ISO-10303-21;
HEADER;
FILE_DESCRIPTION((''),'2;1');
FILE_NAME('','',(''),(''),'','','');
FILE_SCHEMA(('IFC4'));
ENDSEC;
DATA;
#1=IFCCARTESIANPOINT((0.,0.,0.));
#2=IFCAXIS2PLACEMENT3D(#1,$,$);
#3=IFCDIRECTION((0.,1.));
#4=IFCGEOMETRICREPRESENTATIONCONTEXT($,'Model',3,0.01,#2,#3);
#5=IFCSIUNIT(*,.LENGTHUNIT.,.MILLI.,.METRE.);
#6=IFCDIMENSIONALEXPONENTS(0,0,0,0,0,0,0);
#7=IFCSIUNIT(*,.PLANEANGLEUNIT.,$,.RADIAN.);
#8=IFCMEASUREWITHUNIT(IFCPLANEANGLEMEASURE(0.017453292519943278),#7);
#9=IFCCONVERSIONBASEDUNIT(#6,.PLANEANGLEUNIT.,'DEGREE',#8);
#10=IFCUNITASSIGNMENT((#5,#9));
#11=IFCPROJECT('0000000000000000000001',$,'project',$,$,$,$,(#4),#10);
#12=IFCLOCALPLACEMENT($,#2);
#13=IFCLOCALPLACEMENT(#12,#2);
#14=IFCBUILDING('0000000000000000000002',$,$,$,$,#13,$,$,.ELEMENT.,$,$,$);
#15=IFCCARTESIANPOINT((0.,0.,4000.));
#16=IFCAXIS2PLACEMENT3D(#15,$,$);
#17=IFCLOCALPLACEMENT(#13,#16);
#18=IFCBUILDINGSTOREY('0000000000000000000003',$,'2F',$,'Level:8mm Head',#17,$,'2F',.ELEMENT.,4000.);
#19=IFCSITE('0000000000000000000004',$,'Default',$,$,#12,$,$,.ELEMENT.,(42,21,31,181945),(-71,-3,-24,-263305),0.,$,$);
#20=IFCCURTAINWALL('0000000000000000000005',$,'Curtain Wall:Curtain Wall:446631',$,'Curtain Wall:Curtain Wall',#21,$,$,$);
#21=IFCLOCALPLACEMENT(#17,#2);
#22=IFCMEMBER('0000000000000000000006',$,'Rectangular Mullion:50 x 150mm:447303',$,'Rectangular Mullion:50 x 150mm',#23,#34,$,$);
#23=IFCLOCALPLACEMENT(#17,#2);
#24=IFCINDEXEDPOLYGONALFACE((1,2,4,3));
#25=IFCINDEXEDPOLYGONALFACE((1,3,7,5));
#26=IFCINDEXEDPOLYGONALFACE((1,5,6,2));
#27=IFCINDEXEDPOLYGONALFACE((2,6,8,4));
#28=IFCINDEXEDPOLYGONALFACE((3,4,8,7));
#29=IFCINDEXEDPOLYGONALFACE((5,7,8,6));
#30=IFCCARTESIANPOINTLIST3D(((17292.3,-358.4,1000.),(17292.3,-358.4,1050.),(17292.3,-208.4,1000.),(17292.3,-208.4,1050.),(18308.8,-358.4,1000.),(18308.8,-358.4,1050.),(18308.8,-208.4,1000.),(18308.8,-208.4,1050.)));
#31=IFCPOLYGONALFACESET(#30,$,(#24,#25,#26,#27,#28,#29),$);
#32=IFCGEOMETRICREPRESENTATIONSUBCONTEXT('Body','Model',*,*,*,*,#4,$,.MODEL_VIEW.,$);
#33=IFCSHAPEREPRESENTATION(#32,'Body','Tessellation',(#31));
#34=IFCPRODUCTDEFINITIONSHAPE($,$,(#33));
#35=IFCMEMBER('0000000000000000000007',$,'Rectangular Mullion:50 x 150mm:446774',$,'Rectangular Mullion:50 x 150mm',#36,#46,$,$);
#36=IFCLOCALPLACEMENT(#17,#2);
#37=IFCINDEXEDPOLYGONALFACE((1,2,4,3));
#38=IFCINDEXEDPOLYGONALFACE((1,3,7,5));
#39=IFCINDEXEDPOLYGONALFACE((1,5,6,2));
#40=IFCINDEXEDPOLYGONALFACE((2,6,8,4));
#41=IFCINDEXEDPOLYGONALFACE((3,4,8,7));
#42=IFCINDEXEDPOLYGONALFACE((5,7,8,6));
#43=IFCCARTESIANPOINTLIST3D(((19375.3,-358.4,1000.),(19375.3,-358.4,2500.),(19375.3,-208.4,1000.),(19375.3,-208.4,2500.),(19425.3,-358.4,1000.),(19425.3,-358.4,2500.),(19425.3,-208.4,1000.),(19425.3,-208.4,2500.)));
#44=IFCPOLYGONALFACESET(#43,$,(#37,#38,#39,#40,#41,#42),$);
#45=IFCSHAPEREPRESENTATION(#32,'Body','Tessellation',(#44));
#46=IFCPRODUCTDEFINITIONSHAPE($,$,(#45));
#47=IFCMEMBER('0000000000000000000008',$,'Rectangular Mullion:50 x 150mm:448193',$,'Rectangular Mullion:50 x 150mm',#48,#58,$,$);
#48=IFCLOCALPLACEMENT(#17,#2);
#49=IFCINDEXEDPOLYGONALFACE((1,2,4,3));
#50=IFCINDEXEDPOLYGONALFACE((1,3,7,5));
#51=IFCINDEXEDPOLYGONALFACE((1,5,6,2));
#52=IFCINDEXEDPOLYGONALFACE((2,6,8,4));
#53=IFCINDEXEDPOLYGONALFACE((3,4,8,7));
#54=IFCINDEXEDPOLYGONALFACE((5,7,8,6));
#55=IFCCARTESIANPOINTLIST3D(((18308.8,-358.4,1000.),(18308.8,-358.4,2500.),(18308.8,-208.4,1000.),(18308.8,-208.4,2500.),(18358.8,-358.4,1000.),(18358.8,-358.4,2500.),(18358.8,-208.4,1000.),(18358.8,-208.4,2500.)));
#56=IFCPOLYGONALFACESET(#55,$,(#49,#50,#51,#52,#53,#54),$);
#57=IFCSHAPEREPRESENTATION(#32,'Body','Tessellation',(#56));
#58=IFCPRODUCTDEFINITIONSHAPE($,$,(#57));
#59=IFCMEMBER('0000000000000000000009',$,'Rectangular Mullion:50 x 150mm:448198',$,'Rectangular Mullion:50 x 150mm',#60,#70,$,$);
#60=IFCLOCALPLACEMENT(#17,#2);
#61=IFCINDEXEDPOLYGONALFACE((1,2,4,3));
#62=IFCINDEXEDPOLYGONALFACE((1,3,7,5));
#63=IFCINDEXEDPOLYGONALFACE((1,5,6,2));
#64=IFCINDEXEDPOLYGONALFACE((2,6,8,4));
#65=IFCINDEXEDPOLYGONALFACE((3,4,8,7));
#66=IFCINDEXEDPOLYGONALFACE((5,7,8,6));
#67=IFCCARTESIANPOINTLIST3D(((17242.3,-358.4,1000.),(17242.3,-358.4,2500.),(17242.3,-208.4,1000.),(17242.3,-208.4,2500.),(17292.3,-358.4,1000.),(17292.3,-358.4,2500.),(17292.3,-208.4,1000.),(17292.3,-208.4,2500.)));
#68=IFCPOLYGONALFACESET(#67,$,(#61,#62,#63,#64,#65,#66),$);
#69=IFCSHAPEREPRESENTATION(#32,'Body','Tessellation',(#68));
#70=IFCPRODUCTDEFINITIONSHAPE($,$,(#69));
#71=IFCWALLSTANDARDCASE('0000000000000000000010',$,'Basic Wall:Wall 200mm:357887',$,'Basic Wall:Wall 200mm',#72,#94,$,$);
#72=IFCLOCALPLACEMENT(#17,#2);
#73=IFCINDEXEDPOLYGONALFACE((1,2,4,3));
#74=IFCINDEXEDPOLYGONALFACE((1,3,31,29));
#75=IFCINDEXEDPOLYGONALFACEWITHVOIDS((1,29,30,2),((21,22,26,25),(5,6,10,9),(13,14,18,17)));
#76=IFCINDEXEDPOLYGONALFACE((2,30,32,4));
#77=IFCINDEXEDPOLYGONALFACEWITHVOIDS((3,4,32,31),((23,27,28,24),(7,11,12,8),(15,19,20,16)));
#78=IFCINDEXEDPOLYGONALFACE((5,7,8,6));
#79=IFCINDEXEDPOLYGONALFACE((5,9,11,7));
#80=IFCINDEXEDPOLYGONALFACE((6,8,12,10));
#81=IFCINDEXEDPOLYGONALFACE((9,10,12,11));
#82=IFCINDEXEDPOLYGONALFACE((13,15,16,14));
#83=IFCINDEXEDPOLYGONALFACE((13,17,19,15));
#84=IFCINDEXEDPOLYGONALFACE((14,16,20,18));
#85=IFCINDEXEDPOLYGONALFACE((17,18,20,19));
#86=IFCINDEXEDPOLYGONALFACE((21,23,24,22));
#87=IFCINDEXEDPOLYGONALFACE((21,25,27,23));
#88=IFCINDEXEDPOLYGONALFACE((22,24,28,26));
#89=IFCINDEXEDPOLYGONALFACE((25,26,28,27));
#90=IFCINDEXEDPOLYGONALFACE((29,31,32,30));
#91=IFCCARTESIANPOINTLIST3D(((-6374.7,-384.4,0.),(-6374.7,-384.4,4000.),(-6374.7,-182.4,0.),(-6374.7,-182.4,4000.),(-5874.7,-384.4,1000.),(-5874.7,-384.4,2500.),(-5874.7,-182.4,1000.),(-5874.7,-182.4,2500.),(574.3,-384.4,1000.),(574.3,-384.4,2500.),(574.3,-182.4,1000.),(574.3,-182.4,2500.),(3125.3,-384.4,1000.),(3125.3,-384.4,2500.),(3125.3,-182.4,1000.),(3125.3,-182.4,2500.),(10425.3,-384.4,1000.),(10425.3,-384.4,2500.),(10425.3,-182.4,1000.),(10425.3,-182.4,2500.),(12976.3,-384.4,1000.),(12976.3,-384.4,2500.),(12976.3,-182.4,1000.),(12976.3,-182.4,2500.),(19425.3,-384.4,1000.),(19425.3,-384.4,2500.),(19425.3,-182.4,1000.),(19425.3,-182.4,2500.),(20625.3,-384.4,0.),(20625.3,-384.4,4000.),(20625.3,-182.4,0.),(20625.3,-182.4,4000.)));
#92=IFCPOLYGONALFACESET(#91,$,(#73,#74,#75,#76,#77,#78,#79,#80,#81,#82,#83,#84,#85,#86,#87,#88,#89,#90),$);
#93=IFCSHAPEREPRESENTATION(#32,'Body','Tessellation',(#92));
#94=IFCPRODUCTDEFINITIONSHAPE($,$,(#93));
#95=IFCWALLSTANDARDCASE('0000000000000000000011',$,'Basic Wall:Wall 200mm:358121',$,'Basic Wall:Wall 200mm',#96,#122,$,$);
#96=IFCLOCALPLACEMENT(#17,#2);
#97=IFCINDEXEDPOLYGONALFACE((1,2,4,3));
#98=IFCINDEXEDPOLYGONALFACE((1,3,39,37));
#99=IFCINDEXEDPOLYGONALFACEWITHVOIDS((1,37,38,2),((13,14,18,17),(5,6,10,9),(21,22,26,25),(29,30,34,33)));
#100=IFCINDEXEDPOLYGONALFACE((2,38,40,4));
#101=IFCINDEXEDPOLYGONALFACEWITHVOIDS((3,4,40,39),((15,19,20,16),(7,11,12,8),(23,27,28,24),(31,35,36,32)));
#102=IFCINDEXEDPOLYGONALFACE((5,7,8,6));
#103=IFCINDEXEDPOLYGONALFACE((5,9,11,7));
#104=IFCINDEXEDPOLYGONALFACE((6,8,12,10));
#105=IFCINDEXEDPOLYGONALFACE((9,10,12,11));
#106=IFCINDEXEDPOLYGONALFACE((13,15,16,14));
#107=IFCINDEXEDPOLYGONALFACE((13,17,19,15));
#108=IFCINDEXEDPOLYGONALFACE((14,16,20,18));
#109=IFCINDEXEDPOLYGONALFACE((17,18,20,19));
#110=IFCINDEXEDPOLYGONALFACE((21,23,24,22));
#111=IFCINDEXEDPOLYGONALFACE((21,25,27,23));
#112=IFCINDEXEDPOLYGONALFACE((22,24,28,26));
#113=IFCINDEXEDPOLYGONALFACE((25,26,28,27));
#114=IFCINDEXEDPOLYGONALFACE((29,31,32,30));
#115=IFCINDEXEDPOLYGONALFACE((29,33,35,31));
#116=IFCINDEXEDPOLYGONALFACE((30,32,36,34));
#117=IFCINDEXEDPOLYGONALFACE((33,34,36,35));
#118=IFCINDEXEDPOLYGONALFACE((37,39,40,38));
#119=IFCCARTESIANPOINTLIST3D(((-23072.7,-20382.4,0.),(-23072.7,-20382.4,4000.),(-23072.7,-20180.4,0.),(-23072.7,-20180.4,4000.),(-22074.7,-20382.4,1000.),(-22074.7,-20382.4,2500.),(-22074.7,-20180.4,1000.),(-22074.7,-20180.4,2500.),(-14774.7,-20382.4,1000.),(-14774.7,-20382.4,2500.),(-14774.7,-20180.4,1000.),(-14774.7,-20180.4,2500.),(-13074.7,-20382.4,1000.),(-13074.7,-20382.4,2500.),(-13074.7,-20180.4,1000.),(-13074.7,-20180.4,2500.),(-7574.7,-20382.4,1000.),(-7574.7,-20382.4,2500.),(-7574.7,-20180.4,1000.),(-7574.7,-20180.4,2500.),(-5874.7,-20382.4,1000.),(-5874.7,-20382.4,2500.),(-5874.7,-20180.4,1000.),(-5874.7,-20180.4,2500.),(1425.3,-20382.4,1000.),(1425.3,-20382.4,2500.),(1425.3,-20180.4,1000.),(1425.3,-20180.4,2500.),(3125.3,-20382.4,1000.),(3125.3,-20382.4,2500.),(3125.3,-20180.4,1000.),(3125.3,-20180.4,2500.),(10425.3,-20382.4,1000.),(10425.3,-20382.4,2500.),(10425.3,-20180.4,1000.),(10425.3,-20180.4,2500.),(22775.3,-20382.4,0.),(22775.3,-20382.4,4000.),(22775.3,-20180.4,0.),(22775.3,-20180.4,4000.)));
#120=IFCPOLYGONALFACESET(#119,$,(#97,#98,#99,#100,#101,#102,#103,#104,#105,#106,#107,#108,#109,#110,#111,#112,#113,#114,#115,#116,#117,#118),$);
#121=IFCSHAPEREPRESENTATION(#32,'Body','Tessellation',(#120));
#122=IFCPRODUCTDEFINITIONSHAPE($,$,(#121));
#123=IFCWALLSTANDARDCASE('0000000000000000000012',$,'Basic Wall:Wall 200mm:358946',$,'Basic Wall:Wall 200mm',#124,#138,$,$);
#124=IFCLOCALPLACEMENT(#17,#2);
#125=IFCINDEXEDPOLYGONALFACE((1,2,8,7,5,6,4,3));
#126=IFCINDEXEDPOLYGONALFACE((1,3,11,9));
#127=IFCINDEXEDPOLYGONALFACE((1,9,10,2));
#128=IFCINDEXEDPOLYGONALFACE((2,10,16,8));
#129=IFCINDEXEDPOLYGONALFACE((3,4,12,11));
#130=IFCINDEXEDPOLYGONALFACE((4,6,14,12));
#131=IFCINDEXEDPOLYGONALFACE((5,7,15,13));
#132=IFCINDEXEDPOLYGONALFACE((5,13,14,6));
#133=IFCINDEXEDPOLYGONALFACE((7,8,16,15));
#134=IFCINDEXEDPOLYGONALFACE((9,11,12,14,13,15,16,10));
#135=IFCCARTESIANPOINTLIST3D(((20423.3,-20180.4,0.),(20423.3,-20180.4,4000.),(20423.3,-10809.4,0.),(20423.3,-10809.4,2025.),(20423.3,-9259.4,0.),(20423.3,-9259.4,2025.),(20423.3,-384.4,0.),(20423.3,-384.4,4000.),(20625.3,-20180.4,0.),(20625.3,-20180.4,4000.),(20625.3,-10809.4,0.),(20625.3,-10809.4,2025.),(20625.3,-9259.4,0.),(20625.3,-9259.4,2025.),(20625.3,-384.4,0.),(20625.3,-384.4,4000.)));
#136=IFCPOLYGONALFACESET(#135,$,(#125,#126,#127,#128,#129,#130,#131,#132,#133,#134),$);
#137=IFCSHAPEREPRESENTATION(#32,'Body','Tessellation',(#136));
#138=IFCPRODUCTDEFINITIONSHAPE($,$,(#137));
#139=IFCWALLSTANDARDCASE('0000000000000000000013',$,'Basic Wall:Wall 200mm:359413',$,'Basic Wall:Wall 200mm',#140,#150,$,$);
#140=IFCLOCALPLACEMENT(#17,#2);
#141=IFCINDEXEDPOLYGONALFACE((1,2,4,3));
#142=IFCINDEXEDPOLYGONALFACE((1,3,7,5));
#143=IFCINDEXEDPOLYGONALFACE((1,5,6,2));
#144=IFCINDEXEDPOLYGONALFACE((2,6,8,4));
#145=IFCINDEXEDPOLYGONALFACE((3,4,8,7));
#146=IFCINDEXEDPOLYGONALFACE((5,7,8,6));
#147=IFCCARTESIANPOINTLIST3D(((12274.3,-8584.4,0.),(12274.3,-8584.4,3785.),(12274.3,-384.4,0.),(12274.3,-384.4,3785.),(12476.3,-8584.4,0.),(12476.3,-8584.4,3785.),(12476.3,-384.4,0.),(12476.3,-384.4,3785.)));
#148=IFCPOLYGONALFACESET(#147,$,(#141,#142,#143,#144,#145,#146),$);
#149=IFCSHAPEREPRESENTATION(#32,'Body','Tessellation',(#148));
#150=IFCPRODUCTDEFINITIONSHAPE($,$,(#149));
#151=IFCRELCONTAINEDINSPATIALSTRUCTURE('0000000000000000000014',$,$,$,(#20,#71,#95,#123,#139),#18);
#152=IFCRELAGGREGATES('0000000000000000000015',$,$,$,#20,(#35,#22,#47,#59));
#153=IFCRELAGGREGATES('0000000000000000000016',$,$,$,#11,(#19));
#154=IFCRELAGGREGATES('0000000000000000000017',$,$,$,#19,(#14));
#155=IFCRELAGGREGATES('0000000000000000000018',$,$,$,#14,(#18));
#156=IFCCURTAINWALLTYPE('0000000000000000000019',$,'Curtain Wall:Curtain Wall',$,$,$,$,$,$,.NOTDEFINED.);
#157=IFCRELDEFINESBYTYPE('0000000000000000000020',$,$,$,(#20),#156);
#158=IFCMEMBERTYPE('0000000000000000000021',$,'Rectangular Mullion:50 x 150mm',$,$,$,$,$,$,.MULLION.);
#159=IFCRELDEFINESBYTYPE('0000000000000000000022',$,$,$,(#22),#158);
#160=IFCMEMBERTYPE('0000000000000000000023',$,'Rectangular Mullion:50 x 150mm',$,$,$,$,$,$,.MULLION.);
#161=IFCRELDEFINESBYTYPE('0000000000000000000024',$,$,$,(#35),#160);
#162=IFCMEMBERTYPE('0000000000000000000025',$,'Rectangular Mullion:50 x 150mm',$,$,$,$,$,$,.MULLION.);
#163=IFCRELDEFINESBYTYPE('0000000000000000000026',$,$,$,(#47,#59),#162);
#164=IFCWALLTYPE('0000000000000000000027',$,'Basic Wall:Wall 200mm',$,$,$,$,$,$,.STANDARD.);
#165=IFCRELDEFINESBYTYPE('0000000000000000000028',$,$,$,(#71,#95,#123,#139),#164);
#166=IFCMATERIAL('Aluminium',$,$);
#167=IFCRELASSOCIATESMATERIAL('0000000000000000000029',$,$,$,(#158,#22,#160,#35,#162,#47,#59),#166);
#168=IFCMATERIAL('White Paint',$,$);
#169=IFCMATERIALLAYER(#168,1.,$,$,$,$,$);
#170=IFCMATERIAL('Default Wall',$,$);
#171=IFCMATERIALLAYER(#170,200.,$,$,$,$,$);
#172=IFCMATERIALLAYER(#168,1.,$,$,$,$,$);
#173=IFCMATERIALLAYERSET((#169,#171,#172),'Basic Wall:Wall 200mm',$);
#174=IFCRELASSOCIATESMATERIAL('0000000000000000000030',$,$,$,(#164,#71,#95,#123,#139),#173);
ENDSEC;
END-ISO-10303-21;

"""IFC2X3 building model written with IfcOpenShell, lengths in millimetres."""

from ifc_helpers import new_model, entity, si_unit, converted_unit, direction, frame, frame_2d, origin, origin_2d_with_axis, place, context, subcontext, project, spatial, polyline, rectangle, extrude, clip, bounded_halfspace, source, transform, mapped, material, layer, layer_set, layer_usage, type_object, type_shapes, element, aggregate, save


model = new_model("IFC2X3")

# Units and contexts
model_context = context("Model", 3, precision=0.01, world=origin(), true_north=direction((0.0, 1.0)))
body_context = subcontext(model_context, "Body", "Model", "MODEL_VIEW")
ifc_project = project(units=[si_unit("LENGTHUNIT", "METRE", prefix="MILLI"), converted_unit("PLANEANGLEUNIT", "DEGREE", entity("IfcPlaneAngleMeasure", 0.017453292519943278), si_unit("PLANEANGLEUNIT", "RADIAN"), dimensions=[0, 0, 0, 0, 0, 0, 0])], contexts=[model_context])

# Site, building, storey
site_placement = place(None, origin())
site = spatial("IfcSite", under=ifc_project, at=site_placement, Name="Default", CompositionType="ELEMENT", RefLatitude=(42, 21, 31, 181945), RefLongitude=(-71, -3, -24, -263305), RefElevation=0.0)
building_placement = place(site_placement, origin())
building = spatial("IfcBuilding", under=site, at=building_placement, CompositionType="ELEMENT")
storey_placement = place(building_placement, frame((0.0, 0.0, 4000.0)))
storey = spatial("IfcBuildingStorey", under=building, at=storey_placement, Name="2F", ObjectType="Level:8mm Head", LongName="2F", CompositionType="ELEMENT", Elevation=4000.0)

# Curtain wall, members
curtain_wall_type = type_object("IfcCurtainWallType", Name="Curtain Wall:Curtain Wall", PredefinedType="NOTDEFINED")
ifc_material_1 = material(Name="Aluminium")
curtain_wall_1_placement = place(storey_placement, frame((0.0, 0.0, -4000.0)))
curtain_wall_1 = element("IfcCurtainWall", 1, at=curtain_wall_1_placement, inside=storey, type_object=curtain_wall_type, Name="Curtain Wall:Curtain Wall:446631", ObjectType="Curtain Wall:Curtain Wall")
member_type_1 = type_object("IfcMemberType", Name="Rectangular Mullion:50 x 150mm", PredefinedType="MULLION", material=ifc_material_1)
shared_shape_1 = source(origin(), body_context, "Body", "SweptSolid", [
    extrude(rectangle(XDim=50.0, YDim=150.0, at=origin_2d_with_axis()), frame((-25.0, 0.0, -1016.5), z_axis=(0.0, 0.0, 1.0), x_axis=(-1.0, 0.0, 0.0)), (0.0, 0.0, 1.0), 1016.5),
])
type_shapes(member_type_1, [shared_shape_1])
member_1_placement = place(curtain_wall_1_placement, frame((18308.8, -283.4, 5000.0), z_axis=(1.0, 0.0, 0.0), x_axis=(0.0, 0.0, -1.0)))
member_1 = element("IfcMember", 2, at=member_1_placement, type_object=member_type_1, material=ifc_material_1, Name="Rectangular Mullion:50 x 150mm:447303", ObjectType="Rectangular Mullion:50 x 150mm", context=body_context, shape_type="MappedRepresentation", body=[
    mapped(shared_shape_1, transform((0.0, 0.0, 0.0), scale=1.0)),
])
member_type_2 = type_object("IfcMemberType", Name="Rectangular Mullion:50 x 150mm", PredefinedType="MULLION", material=ifc_material_1)
shared_shape_2 = source(origin(), body_context, "Body", "SweptSolid", [
    extrude(rectangle(XDim=50.0, YDim=150.0, at=origin_2d_with_axis()), frame((-25.0, 0.0, -1500.0), z_axis=(0.0, 0.0, 1.0), x_axis=(-1.0, 0.0, 0.0)), (0.0, 0.0, 1.0), 1500.0),
])
type_shapes(member_type_2, [shared_shape_2])
member_2_placement = place(curtain_wall_1_placement, frame((19425.3, -283.4, 6500.0)))
member_2 = element("IfcMember", 3, at=member_2_placement, type_object=member_type_2, material=ifc_material_1, Name="Rectangular Mullion:50 x 150mm:446774", ObjectType="Rectangular Mullion:50 x 150mm", context=body_context, shape_type="MappedRepresentation", body=[
    mapped(shared_shape_2, transform((0.0, 0.0, 0.0), scale=1.0)),
])
member_type_3 = type_object("IfcMemberType", Name="Rectangular Mullion:50 x 150mm", PredefinedType="MULLION", material=ifc_material_1)
shared_shape_3 = source(origin(), body_context, "Body", "SweptSolid", [
    extrude(rectangle(XDim=50.0, YDim=150.0, at=origin_2d_with_axis()), frame((0.0, 0.0, -1500.0), z_axis=(0.0, 0.0, 1.0), x_axis=(-1.0, 0.0, 0.0)), (0.0, 0.0, 1.0), 1500.0),
])
type_shapes(member_type_3, [shared_shape_3])
member_3_placement = place(curtain_wall_1_placement, frame((18333.8, -283.4, 5000.0), z_axis=(0.0, 0.0, -1.0), x_axis=(-1.0, 0.0, 0.0)))
member_3 = element("IfcMember", 4, at=member_3_placement, type_object=member_type_3, material=ifc_material_1, Name="Rectangular Mullion:50 x 150mm:448193", ObjectType="Rectangular Mullion:50 x 150mm", context=body_context, shape_type="MappedRepresentation", body=[
    mapped(shared_shape_3, transform((0.0, 0.0, 0.0), scale=1.0)),
])
member_4_placement = place(curtain_wall_1_placement, frame((17267.3, -283.4, 5000.0), z_axis=(0.0, 0.0, -1.0), x_axis=(-1.0, 0.0, 0.0)))
member_4 = element("IfcMember", 5, at=member_4_placement, type_object=member_type_3, material=ifc_material_1, Name="Rectangular Mullion:50 x 150mm:448198", ObjectType="Rectangular Mullion:50 x 150mm", context=body_context, shape_type="MappedRepresentation", body=[
    mapped(shared_shape_3, transform((0.0, 0.0, 0.0), scale=1.0)),
])

aggregate(curtain_wall_1, [member_2, member_1, member_3, member_4])

# Walls, openings
ifc_material_2 = material(Name="White Paint")
ifc_layer_1 = layer(ifc_material_2, 1.0)
ifc_material_3 = material(Name="Default Wall")
ifc_layer_2 = layer(ifc_material_3, 200.0)
ifc_layer_3 = layer(ifc_material_2, 1.0)
ifc_layer_set_1 = layer_set([ifc_layer_1, ifc_layer_2, ifc_layer_3], Name="Basic Wall:Wall 200mm")
ifc_layer_usage_1 = layer_usage(ifc_layer_set_1, "AXIS2", "POSITIVE", -101.0)
wall_type_1 = type_object("IfcWallType", Name="Basic Wall:Wall 200mm", PredefinedType="STANDARD", material=ifc_layer_set_1)
wall_1_placement = place(storey_placement, frame((20625.3, -283.4, 0.0), z_axis=(0.0, 0.0, 1.0), x_axis=(-1.0, 0.0, 0.0)))
wall_1 = element("IfcWallStandardCase", 6, at=wall_1_placement, inside=storey, type_object=wall_type_1, material=ifc_layer_usage_1, Name="Basic Wall:Wall 200mm:357887", ObjectType="Basic Wall:Wall 200mm", context=body_context, shape_type="SweptSolid", body=[
    extrude(rectangle(XDim=27000.0, YDim=202.0, at=frame_2d((13500.0, 0.0), x_axis=(-1.0, 0.0))), origin(), (0.0, 0.0, 1.0), 4000.0),
])
opening_1_placement = place(wall_1_placement, origin())
element("IfcOpeningElement", 7, at=opening_1_placement, cuts=wall_1, ObjectType="Opening", context=body_context, shape_type="SweptSolid", body=[
    extrude(rectangle(XDim=1500.0, YDim=6449.0, at=frame_2d((0.0, 0.0), x_axis=(0.0, 1.0))), frame((4424.5, 101.0, 1750.0), z_axis=(0.0, -1.0, 0.0), x_axis=(-1.0, 0.0, 0.0)), (0.0, 0.0, 1.0), 202.0),
])
opening_2_placement = place(wall_1_placement, origin())
element("IfcOpeningElement", 8, at=opening_2_placement, cuts=wall_1, ObjectType="Opening", context=body_context, shape_type="SweptSolid", body=[
    extrude(rectangle(XDim=1500.0, YDim=7300.0, at=frame_2d((0.0, 0.0), x_axis=(0.0, 1.0))), frame((13850.0, 101.0, 1750.0), z_axis=(0.0, -1.0, 0.0), x_axis=(-1.0, 0.0, 0.0)), (0.0, 0.0, 1.0), 202.0),
])
opening_3_placement = place(wall_1_placement, origin())
element("IfcOpeningElement", 9, at=opening_3_placement, cuts=wall_1, ObjectType="Opening", context=body_context, shape_type="SweptSolid", body=[
    extrude(rectangle(XDim=1500.0, YDim=6449.0, at=frame_2d((0.0, 0.0), x_axis=(0.0, -1.0))), frame((23275.5, 101.0, 1750.0), z_axis=(0.0, 1.0, 0.0), x_axis=(-1.0, 0.0, 0.0)), (0.0, 0.0, -1.0), 202.0),
])
ifc_layer_usage_2 = layer_usage(ifc_layer_set_1, "AXIS2", "NEGATIVE", 101.0)
wall_2_placement = place(storey_placement, frame((22775.3, -20281.4, 0.0), z_axis=(0.0, 0.0, 1.0), x_axis=(-1.0, 0.0, 0.0)))
wall_2 = element("IfcWallStandardCase", 10, at=wall_2_placement, inside=storey, type_object=wall_type_1, material=ifc_layer_usage_2, Name="Basic Wall:Wall 200mm:358121", ObjectType="Basic Wall:Wall 200mm", context=body_context, shape_type="SweptSolid", body=[
    extrude(rectangle(XDim=45848.0, YDim=202.0, at=frame_2d((22924.0, 0.0), x_axis=(-1.0, 0.0))), origin(), (0.0, 0.0, 1.0), 4000.0),
])
opening_4_placement = place(wall_2_placement, origin())
element("IfcOpeningElement", 11, at=opening_4_placement, cuts=wall_2, ObjectType="Opening", context=body_context, shape_type="SweptSolid", body=[
    extrude(rectangle(XDim=1500.0, YDim=7300.0, at=frame_2d((0.0, 0.0), x_axis=(1.0, 0.0))), frame((41200.0, 101.0, 1750.0), z_axis=(0.0, -1.0, 0.0), x_axis=(0.0, 0.0, -1.0)), (0.0, 0.0, 1.0), 202.0),
])
opening_5_placement = place(wall_2_placement, origin())
element("IfcOpeningElement", 12, at=opening_5_placement, cuts=wall_2, ObjectType="Opening", context=body_context, shape_type="SweptSolid", body=[
    extrude(rectangle(XDim=1500.0, YDim=5500.0, at=frame_2d((0.0, 0.0), x_axis=(1.0, 0.0))), frame((33100.0, 101.0, 1750.0), z_axis=(0.0, 1.0, 0.0), x_axis=(0.0, 0.0, -1.0)), (0.0, 0.0, -1.0), 202.0),
])
opening_6_placement = place(wall_2_placement, origin())
element("IfcOpeningElement", 13, at=opening_6_placement, cuts=wall_2, ObjectType="Opening", context=body_context, shape_type="SweptSolid", body=[
    extrude(rectangle(XDim=1500.0, YDim=7300.0, at=frame_2d((0.0, 0.0), x_axis=(1.0, 0.0))), frame((25000.0, 101.0, 1750.0), z_axis=(0.0, -1.0, 0.0), x_axis=(0.0, 0.0, -1.0)), (0.0, 0.0, 1.0), 202.0),
])
opening_7_placement = place(wall_2_placement, origin())
element("IfcOpeningElement", 14, at=opening_7_placement, cuts=wall_2, ObjectType="Opening", context=body_context, shape_type="SweptSolid", body=[
    extrude(rectangle(XDim=1500.0, YDim=7300.0, at=frame_2d((0.0, 0.0), x_axis=(1.0, 0.0))), frame((16000.0, 101.0, 1750.0), z_axis=(0.0, -1.0, 0.0), x_axis=(0.0, 0.0, -1.0)), (0.0, 0.0, 1.0), 202.0),
])

# Wall, opening
ifc_layer_usage_3 = layer_usage(ifc_layer_set_1, "AXIS2", "POSITIVE", -101.0)
wall_3_placement = place(storey_placement, frame((20524.3, -20180.4, 0.0), z_axis=(0.0, 0.0, 1.0), x_axis=(0.0, 1.0, 0.0)))
wall_3 = element("IfcWallStandardCase", 15, at=wall_3_placement, inside=storey, type_object=wall_type_1, material=ifc_layer_usage_3, Name="Basic Wall:Wall 200mm:358946", ObjectType="Basic Wall:Wall 200mm", context=body_context, shape_type="SweptSolid", body=[
    extrude(rectangle(XDim=202.0, YDim=19796.0, at=frame_2d((9898.0, 0.0), x_axis=(0.0, -1.0))), origin(), (0.0, 0.0, 1.0), 4000.0),
])
opening_8_placement = place(wall_3_placement, frame((10921.0, 101.0, 0.0)))
element("IfcOpeningElement", 16, at=opening_8_placement, cuts=wall_3, ObjectType="Opening", context=body_context, shape_type="SweptSolid", body=[
    extrude(rectangle(XDim=2025.0, YDim=1550.0, at=frame_2d((1012.5, 775.0), x_axis=(1.0, 0.0))), frame((0.0, 0.0, 0.0), z_axis=(0.0, -1.0, 0.0), x_axis=(0.0, 0.0, 1.0)), (0.0, 0.0, 1.0), 202.0),
])

# Wall
ifc_layer_usage_4 = layer_usage(ifc_layer_set_1, "AXIS2", "POSITIVE", -101.0)
wall_4_placement = place(storey_placement, frame((12375.3, -8584.4, 0.0), z_axis=(0.0, 0.0, 1.0), x_axis=(0.0, 1.0, 0.0)))
element("IfcWallStandardCase", 17, at=wall_4_placement, inside=storey, type_object=wall_type_1, material=ifc_layer_usage_4, Name="Basic Wall:Wall 200mm:359413", ObjectType="Basic Wall:Wall 200mm", context=body_context, shape_type="Clipping", body=[
    clip(extrude(rectangle(XDim=8200.0, YDim=202.0, at=frame_2d((4100.0, 0.0), x_axis=(-1.0, 0.0))), origin(), (0.0, 0.0, 1.0), 3785.0), bounded_halfspace(frame((0.0, -101.0, 3785.0), z_axis=(0.0, 0.0, -1.0), x_axis=(0.0, -1.0, 0.0)), True, frame((0.0, -101.0, 3785.0), z_axis=(0.0, 0.0, -1.0), x_axis=(0.0, -1.0, 0.0)), polyline([(0.0, 0.0), (-202.0, 0.0), (-202.0, -8200.0), (0.0, -8200.0), (0.0, 0.0)]))),
])

save(model, "model.ifc")
